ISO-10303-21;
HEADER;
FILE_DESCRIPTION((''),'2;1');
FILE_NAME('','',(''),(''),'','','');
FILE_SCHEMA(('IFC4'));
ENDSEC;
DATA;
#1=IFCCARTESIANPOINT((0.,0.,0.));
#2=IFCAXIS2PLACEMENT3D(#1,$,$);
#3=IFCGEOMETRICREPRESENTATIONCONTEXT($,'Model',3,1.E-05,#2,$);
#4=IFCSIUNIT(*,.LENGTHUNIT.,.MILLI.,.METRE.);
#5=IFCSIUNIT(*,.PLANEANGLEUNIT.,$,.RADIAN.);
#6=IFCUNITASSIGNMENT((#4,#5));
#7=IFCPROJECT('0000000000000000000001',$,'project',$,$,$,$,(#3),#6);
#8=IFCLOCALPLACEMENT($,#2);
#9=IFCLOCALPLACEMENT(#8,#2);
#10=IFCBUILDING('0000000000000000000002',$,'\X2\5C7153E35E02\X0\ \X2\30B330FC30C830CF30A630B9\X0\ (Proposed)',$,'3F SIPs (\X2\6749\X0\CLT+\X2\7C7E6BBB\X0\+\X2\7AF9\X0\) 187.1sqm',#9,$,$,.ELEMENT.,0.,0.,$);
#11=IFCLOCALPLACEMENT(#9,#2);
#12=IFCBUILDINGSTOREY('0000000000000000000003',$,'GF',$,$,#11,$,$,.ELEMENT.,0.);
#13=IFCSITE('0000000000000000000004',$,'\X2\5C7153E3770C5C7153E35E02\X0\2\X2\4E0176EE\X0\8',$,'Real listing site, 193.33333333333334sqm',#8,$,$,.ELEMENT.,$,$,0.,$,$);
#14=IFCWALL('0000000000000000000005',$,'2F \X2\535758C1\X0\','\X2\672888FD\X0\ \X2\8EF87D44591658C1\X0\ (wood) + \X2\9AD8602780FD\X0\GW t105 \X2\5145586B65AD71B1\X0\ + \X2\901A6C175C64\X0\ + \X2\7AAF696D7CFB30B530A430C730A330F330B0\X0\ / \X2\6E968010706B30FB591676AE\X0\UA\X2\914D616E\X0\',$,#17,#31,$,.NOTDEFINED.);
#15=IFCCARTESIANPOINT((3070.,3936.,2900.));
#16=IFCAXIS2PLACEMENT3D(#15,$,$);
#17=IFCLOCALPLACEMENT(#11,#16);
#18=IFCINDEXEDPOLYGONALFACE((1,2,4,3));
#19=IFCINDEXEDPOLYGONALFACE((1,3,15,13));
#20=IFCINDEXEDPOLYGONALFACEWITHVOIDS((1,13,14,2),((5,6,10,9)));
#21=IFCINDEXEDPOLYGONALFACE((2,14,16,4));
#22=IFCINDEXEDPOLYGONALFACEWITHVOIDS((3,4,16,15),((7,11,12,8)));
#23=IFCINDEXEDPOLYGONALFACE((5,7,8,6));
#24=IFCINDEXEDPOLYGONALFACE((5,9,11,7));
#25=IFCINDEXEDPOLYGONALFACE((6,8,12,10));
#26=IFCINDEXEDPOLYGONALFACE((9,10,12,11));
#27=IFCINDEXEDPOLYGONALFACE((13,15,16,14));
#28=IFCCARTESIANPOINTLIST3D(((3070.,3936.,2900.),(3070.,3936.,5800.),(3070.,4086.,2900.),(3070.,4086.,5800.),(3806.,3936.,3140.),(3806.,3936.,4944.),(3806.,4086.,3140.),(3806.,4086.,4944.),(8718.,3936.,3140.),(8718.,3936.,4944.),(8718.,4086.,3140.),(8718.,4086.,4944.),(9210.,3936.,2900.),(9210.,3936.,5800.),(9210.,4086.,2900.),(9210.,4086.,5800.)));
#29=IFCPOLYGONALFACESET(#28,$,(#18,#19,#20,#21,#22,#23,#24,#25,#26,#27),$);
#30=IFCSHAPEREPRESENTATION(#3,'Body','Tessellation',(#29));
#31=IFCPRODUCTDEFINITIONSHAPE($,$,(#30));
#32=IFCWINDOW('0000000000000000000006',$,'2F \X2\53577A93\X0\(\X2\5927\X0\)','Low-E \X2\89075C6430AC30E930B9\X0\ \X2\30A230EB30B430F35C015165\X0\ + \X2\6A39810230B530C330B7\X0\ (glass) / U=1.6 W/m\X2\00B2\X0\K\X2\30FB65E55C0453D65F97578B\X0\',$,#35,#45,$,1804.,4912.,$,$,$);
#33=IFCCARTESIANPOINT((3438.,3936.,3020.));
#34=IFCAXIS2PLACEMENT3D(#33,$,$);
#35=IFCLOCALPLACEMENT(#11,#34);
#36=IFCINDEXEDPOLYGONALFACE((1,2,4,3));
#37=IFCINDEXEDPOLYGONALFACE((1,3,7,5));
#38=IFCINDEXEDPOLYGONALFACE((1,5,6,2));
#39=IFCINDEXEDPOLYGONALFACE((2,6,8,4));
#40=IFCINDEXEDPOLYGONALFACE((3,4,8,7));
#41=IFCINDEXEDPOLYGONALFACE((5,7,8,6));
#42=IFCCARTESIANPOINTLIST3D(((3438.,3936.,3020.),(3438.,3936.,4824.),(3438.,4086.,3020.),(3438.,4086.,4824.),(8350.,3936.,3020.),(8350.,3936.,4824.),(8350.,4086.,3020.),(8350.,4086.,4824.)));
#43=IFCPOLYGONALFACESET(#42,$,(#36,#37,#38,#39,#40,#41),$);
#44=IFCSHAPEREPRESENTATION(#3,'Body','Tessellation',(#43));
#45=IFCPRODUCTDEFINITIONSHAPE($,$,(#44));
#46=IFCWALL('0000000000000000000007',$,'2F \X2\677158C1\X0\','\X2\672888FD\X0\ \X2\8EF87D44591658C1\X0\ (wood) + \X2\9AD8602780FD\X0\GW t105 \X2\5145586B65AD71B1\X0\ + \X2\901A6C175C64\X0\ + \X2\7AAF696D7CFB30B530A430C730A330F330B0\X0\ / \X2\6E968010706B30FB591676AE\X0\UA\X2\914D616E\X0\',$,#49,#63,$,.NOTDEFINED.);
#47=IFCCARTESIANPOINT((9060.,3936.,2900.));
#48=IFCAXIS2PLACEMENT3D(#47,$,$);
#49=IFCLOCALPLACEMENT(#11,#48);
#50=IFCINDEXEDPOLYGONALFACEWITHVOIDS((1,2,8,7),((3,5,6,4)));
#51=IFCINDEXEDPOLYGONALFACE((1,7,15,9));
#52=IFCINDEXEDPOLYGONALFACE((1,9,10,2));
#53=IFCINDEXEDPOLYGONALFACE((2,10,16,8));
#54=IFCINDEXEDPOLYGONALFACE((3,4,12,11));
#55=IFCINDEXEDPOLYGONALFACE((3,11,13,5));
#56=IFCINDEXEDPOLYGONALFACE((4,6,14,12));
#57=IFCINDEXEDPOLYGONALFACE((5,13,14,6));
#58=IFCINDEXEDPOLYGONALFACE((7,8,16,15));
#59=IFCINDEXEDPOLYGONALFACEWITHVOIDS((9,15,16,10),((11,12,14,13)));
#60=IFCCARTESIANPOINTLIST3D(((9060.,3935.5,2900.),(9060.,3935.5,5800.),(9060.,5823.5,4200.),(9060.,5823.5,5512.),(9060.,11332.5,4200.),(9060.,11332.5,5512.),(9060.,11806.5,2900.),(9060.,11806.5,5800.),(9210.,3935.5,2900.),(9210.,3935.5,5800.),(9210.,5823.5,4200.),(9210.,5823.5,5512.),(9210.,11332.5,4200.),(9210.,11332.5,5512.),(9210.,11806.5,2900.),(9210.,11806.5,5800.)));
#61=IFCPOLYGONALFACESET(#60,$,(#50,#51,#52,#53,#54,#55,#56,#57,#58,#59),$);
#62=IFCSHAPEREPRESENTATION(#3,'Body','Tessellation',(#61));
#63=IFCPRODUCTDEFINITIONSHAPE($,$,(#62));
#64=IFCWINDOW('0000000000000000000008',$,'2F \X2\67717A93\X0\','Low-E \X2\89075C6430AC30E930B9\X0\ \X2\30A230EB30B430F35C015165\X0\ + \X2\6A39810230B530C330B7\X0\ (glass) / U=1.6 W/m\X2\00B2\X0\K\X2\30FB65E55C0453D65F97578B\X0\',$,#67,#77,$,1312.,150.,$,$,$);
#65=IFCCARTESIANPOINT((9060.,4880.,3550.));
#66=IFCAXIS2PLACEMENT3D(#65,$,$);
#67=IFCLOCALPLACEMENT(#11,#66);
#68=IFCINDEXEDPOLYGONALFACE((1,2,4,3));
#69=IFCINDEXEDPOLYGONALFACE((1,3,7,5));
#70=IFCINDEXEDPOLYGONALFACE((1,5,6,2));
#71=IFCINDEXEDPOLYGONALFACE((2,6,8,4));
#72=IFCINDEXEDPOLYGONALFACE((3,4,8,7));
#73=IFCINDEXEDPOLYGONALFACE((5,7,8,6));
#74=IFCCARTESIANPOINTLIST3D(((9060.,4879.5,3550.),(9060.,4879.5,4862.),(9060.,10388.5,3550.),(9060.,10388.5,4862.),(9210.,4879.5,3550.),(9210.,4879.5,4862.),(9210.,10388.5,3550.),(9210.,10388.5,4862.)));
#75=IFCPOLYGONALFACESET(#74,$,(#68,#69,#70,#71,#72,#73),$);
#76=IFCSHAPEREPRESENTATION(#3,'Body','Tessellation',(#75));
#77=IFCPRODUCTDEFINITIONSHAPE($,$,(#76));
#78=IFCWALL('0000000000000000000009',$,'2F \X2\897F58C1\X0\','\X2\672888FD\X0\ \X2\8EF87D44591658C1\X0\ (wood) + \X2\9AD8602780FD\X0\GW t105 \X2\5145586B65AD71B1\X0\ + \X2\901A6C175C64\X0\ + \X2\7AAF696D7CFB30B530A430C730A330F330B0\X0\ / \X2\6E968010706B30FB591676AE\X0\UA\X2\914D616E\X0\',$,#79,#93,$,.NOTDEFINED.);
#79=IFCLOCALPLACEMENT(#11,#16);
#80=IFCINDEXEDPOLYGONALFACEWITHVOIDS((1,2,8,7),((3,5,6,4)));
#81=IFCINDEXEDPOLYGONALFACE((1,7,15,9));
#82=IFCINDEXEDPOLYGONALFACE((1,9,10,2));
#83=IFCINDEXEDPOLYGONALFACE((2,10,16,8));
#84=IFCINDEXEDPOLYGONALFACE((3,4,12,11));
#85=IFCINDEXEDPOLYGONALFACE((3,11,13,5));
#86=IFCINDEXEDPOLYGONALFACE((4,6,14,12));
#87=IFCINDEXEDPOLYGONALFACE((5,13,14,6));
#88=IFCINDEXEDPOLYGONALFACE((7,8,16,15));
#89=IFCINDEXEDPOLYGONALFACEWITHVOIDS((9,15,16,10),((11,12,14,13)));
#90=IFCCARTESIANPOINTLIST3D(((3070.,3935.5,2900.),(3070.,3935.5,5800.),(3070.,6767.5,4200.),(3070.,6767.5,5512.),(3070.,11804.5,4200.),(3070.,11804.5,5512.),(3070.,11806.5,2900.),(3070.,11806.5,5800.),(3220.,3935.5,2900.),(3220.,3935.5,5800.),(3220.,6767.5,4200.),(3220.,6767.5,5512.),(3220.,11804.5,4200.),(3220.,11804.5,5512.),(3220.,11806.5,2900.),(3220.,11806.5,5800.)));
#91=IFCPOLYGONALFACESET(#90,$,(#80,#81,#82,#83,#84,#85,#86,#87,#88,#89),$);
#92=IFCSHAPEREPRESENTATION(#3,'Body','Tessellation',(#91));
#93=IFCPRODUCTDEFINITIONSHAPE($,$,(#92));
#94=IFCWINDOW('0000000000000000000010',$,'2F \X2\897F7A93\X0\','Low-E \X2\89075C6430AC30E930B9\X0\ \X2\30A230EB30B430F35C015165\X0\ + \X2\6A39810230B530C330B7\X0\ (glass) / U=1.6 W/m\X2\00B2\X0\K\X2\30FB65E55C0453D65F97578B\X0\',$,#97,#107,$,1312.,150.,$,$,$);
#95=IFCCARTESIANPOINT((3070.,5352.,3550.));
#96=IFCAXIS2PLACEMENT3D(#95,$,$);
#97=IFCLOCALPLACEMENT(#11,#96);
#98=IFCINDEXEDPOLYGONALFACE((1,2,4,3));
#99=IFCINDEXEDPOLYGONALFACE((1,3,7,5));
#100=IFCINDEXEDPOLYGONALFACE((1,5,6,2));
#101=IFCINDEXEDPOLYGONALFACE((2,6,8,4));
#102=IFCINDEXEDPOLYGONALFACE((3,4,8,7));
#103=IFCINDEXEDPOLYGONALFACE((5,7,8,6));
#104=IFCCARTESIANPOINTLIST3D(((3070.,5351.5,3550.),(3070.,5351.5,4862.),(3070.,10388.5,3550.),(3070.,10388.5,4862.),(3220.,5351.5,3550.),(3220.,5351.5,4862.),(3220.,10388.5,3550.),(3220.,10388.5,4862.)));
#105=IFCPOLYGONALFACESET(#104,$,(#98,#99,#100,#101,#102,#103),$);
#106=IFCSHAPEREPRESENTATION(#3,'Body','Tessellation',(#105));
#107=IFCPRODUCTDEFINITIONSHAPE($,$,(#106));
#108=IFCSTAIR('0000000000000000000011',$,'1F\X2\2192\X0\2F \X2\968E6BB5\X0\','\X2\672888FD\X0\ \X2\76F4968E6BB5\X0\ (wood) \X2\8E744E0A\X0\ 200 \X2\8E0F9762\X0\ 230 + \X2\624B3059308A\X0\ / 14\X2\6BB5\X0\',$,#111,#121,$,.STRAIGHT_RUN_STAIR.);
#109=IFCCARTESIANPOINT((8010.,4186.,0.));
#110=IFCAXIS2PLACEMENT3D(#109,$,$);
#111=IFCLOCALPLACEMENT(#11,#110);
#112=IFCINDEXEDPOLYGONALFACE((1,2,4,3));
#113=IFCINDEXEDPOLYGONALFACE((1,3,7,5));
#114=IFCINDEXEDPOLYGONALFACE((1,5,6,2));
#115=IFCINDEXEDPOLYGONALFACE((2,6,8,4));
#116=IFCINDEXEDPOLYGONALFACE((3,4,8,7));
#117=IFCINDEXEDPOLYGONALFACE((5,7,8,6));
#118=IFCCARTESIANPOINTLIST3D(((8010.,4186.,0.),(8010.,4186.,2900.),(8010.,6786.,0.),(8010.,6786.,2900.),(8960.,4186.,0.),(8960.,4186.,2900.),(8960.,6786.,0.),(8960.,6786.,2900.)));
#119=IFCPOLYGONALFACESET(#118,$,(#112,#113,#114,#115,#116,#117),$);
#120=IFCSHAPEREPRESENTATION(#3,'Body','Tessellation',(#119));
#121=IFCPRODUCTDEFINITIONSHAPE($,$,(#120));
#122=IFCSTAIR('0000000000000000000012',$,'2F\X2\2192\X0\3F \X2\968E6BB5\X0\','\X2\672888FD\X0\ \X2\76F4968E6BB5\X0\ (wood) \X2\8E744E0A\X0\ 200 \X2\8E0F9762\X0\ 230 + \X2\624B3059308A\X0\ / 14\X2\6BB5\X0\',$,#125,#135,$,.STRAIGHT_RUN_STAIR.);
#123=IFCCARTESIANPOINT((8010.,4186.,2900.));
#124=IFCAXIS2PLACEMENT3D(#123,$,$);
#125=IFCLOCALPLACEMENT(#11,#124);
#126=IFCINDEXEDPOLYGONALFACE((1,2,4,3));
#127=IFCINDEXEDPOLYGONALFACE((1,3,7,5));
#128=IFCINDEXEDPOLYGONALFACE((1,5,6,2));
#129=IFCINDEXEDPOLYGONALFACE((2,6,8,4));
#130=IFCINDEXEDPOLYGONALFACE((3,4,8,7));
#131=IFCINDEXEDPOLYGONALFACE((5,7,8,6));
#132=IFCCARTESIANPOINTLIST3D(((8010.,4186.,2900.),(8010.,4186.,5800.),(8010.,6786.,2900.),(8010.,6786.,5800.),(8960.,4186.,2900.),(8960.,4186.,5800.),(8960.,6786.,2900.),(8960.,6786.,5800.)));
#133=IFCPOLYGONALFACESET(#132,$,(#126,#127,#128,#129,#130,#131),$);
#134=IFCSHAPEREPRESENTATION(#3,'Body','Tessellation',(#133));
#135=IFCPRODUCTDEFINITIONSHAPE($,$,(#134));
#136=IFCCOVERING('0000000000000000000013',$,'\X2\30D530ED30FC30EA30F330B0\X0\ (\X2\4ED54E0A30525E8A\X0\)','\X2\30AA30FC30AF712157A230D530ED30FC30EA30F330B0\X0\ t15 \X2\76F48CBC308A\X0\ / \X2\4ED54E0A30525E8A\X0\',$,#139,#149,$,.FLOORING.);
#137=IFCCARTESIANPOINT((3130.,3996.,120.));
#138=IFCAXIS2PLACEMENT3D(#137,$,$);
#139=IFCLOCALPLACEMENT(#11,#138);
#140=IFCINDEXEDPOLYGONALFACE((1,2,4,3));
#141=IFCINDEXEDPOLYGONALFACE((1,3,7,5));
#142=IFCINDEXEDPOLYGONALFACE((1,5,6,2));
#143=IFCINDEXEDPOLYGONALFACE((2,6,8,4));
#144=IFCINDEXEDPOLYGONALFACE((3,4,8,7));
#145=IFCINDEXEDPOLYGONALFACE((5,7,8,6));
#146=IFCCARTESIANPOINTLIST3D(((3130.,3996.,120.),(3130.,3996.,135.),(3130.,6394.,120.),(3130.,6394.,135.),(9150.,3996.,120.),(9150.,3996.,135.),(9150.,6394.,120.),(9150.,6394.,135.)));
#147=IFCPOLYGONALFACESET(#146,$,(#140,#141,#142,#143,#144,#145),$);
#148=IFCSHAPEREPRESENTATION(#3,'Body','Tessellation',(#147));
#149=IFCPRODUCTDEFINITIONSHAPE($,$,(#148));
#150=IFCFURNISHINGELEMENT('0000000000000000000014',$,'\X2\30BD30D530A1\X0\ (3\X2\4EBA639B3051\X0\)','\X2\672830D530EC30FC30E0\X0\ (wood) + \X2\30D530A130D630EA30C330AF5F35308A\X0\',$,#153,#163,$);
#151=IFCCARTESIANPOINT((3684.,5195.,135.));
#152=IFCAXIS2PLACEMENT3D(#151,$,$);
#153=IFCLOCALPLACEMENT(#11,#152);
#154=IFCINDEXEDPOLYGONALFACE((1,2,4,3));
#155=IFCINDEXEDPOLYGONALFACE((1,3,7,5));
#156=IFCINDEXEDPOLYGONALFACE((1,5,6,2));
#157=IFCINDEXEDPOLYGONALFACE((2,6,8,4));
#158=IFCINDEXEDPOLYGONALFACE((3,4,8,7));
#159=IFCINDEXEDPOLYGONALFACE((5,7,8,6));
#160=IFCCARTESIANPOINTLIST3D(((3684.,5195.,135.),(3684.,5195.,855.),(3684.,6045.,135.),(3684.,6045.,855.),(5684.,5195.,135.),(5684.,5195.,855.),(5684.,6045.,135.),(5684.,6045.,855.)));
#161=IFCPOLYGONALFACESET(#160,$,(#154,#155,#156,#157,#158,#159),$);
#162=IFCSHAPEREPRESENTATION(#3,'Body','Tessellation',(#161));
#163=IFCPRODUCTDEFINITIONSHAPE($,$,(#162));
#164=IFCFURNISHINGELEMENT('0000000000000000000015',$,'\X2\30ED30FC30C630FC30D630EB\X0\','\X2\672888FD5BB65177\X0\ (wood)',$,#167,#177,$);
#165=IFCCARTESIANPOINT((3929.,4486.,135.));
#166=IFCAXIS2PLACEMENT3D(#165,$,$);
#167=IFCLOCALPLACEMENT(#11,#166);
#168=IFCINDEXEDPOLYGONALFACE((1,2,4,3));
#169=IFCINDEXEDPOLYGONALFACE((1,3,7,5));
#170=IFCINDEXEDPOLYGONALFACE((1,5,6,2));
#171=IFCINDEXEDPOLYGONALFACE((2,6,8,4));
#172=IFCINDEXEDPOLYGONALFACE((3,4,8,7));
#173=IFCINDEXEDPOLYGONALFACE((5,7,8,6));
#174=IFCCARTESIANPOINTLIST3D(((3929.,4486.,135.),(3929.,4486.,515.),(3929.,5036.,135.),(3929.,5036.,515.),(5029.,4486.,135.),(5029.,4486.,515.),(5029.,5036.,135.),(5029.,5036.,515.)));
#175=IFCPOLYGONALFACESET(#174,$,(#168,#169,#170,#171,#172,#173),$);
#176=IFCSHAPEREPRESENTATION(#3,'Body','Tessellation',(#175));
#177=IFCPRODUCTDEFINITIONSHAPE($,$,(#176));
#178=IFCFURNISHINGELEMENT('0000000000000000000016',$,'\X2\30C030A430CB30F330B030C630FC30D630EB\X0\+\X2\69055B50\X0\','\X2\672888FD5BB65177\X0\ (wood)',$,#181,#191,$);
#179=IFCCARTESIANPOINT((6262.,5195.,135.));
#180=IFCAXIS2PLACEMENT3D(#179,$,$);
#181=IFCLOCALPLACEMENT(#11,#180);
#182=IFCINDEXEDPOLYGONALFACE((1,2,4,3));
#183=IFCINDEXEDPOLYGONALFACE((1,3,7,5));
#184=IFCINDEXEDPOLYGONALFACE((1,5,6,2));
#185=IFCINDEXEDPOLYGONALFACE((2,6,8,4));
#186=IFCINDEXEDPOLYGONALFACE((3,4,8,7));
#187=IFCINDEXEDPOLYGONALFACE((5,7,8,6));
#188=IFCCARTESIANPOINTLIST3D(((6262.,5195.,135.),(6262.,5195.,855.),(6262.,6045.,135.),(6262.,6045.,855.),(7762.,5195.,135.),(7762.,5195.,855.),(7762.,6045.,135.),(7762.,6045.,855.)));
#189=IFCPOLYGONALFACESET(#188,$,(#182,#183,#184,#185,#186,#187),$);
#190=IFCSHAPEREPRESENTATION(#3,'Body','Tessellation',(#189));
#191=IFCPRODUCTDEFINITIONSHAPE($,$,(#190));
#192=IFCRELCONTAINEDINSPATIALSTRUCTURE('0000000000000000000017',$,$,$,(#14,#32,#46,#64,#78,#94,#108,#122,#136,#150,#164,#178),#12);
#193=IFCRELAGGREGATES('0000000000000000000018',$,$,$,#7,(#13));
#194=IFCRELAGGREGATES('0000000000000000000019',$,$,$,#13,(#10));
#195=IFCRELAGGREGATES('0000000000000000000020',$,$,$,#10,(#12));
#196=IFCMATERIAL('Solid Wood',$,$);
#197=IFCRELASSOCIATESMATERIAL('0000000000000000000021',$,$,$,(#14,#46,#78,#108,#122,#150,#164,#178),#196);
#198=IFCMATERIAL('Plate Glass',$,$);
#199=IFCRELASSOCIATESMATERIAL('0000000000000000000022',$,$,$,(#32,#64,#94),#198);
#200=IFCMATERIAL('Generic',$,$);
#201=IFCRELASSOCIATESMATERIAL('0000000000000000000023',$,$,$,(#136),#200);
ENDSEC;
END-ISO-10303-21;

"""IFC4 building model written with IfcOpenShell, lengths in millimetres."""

from ifc_helpers import new_model, si_unit, frame, frame_2d, origin, place, context, project, spatial, rectangle, extrude, material, element, fill, save


model = new_model("IFC4")

# Units and contexts
model_context = context("Model", 3, precision=1e-05, world=origin())
ifc_project = project(units=[si_unit("LENGTHUNIT", "METRE", prefix="MILLI"), si_unit("PLANEANGLEUNIT", "RADIAN")], contexts=[model_context])

# Site, building, storey
site_placement = place(None, origin())
site = spatial("IfcSite", under=ifc_project, at=site_placement, Name="山口県山口市2丁目8", ObjectType="Real listing site, 193.33333333333334sqm", CompositionType="ELEMENT", RefElevation=0.0)
building_placement = place(site_placement, origin())
building = spatial("IfcBuilding", under=site, at=building_placement, Name="山口市 コートハウス (Proposed)", ObjectType="3F SIPs (杉CLT+籾殻+竹) 187.1sqm", CompositionType="ELEMENT", ElevationOfRefHeight=0.0, ElevationOfTerrain=0.0)
storey_placement = place(building_placement, origin())
storey = spatial("IfcBuildingStorey", under=building, at=storey_placement, Name="GF", CompositionType="ELEMENT", Elevation=0.0)

# Shared definitions
ifc_material_1 = material(Name="Solid Wood")
ifc_material_2 = material(Name="Generic")

# Shared definitions
ifc_material_3 = material(Name="Plate Glass")

# Walls, openings, windows
wall_1_placement = place(storey_placement, frame((3070.0, 3936.0, 2900.0)))
wall_1 = element("IfcWall", 1, at=wall_1_placement, inside=storey, material=ifc_material_1, Name="2F 南壁", Description="木製 軸組外壁 (wood) + 高性能GW t105 充填断熱 + 通気層 + 窯業系サイディング / 準耐火・外皮UA配慮", PredefinedType="NOTDEFINED", context=model_context, shape_type="SweptSolid", body=[
    extrude(rectangle(XDim=6140.0, YDim=150.0, at=frame_2d((3070.0, 75.0))), frame((3070.0, 3936.0, 2900.0)), (0.0, 0.0, 1.0), 2900.0),
])
opening_1_placement = place(storey_placement, frame((3438.0, 3936.0, 3020.0)))
opening_1 = element("IfcOpeningElement", 2, at=opening_1_placement, cuts=wall_1, PredefinedType="NOTDEFINED", context=model_context, shape_type="SweptSolid", body=[
    extrude(rectangle(XDim=4912.0, YDim=150.0, at=frame_2d((2456.0, 75.0))), frame((3438.0, 3936.0, 3020.0)), (0.0, 0.0, 1.0), 1804.0),
])
window_1_placement = place(storey_placement, frame((3438.0, 3936.0, 3020.0)))
window_1 = element("IfcWindow", 3, at=window_1_placement, inside=storey, material=ifc_material_3, Name="2F 南窓(大)", Description="Low-E 複層ガラス アルゴン封入 + 樹脂サッシ (glass) / U=1.6 W/m²K・日射取得型", OverallHeight=1804.0, OverallWidth=4912.0, context=model_context, shape_type="SweptSolid", body=[
    extrude(rectangle(XDim=4912.0, YDim=150.0, at=frame_2d((2456.0, 75.0))), frame((3438.0, 3936.0, 3020.0)), (0.0, 0.0, 1.0), 1804.0),
])
fill(opening_1, window_1)
wall_2_placement = place(storey_placement, frame((9060.0, 3936.0, 2900.0)))
wall_2 = element("IfcWall", 4, at=wall_2_placement, inside=storey, material=ifc_material_1, Name="2F 東壁", Description="木製 軸組外壁 (wood) + 高性能GW t105 充填断熱 + 通気層 + 窯業系サイディング / 準耐火・外皮UA配慮", PredefinedType="NOTDEFINED", context=model_context, shape_type="SweptSolid", body=[
    extrude(rectangle(XDim=150.0, YDim=7871.0, at=frame_2d((75.0, 3935.0))), frame((9060.0, 3936.0, 2900.0)), (0.0, 0.0, 1.0), 2900.0),
])
opening_2_placement = place(storey_placement, frame((9060.0, 4880.0, 3550.0)))
opening_2 = element("IfcOpeningElement", 5, at=opening_2_placement, cuts=wall_2, PredefinedType="NOTDEFINED", context=model_context, shape_type="SweptSolid", body=[
    extrude(rectangle(XDim=150.0, YDim=5509.0, at=frame_2d((75.0, 2754.0))), frame((9060.0, 4880.0, 3550.0)), (0.0, 0.0, 1.0), 1312.0),
])
window_2_placement = place(storey_placement, frame((9060.0, 4880.0, 3550.0)))
window_2 = element("IfcWindow", 6, at=window_2_placement, inside=storey, material=ifc_material_3, Name="2F 東窓", Description="Low-E 複層ガラス アルゴン封入 + 樹脂サッシ (glass) / U=1.6 W/m²K・日射取得型", OverallHeight=1312.0, OverallWidth=150.0, context=model_context, shape_type="SweptSolid", body=[
    extrude(rectangle(XDim=150.0, YDim=5509.0, at=frame_2d((75.0, 2754.0))), frame((9060.0, 4880.0, 3550.0)), (0.0, 0.0, 1.0), 1312.0),
])
fill(opening_2, window_2)
wall_3_placement = place(storey_placement, frame((3070.0, 3936.0, 2900.0)))
wall_3 = element("IfcWall", 7, at=wall_3_placement, inside=storey, material=ifc_material_1, Name="2F 西壁", Description="木製 軸組外壁 (wood) + 高性能GW t105 充填断熱 + 通気層 + 窯業系サイディング / 準耐火・外皮UA配慮", PredefinedType="NOTDEFINED", context=model_context, shape_type="SweptSolid", body=[
    extrude(rectangle(XDim=150.0, YDim=7871.0, at=frame_2d((75.0, 3935.0))), frame((3070.0, 3936.0, 2900.0)), (0.0, 0.0, 1.0), 2900.0),
])
opening_3_placement = place(storey_placement, frame((3070.0, 5352.0, 3550.0)))
opening_3 = element("IfcOpeningElement", 8, at=opening_3_placement, cuts=wall_3, PredefinedType="NOTDEFINED", context=model_context, shape_type="SweptSolid", body=[
    extrude(rectangle(XDim=150.0, YDim=5037.0, at=frame_2d((75.0, 2518.0))), frame((3070.0, 5352.0, 3550.0)), (0.0, 0.0, 1.0), 1312.0),
])
window_3_placement = place(storey_placement, frame((3070.0, 5352.0, 3550.0)))
window_3 = element("IfcWindow", 9, at=window_3_placement, inside=storey, material=ifc_material_3, Name="2F 西窓", Description="Low-E 複層ガラス アルゴン封入 + 樹脂サッシ (glass) / U=1.6 W/m²K・日射取得型", OverallHeight=1312.0, OverallWidth=150.0, context=model_context, shape_type="SweptSolid", body=[
    extrude(rectangle(XDim=150.0, YDim=5037.0, at=frame_2d((75.0, 2518.0))), frame((3070.0, 5352.0, 3550.0)), (0.0, 0.0, 1.0), 1312.0),
])
fill(opening_3, window_3)

# Stairs
stair_1_placement = place(storey_placement, frame((8010.0, 4186.0, 0.0)))
element("IfcStair", 10, at=stair_1_placement, inside=storey, material=ifc_material_1, Name="1F→2F 階段", Description="木製 直階段 (wood) 蹴上 200 踏面 230 + 手すり / 14段", PredefinedType="STRAIGHT_RUN_STAIR", context=model_context, shape_type="SweptSolid", body=[
    extrude(rectangle(XDim=950.0, YDim=2600.0, at=frame_2d((475.0, 1300.0))), frame((8010.0, 4186.0, 0.0)), (0.0, 0.0, 1.0), 2900.0),
])
stair_2_placement = place(storey_placement, frame((8010.0, 4186.0, 2900.0)))
element("IfcStair", 11, at=stair_2_placement, inside=storey, material=ifc_material_1, Name="2F→3F 階段", Description="木製 直階段 (wood) 蹴上 200 踏面 230 + 手すり / 14段", PredefinedType="STRAIGHT_RUN_STAIR", context=model_context, shape_type="SweptSolid", body=[
    extrude(rectangle(XDim=950.0, YDim=2600.0, at=frame_2d((475.0, 1300.0))), frame((8010.0, 4186.0, 2900.0)), (0.0, 0.0, 1.0), 2900.0),
])

# Covering
covering_placement = place(storey_placement, frame((3130.0, 3996.0, 120.0)))
element("IfcCovering", 12, at=covering_placement, inside=storey, material=ifc_material_2, Name="フローリング (仕上げ床)", Description="オーク無垢フローリング t15 直貼り / 仕上げ床", PredefinedType="FLOORING", context=model_context, shape_type="SweptSolid", body=[
    extrude(rectangle(XDim=6020.0, YDim=2398.0, at=frame_2d((3010.0, 1199.0))), frame((3130.0, 3996.0, 120.0)), (0.0, 0.0, 1.0), 15.0),
])

# Furnishing elements
furnishing_1_placement = place(storey_placement, frame((3684.0, 5195.0, 135.0)))
element("IfcFurnishingElement", 13, at=furnishing_1_placement, inside=storey, material=ifc_material_1, Name="ソファ (3人掛け)", Description="木フレーム (wood) + ファブリック張り", context=model_context, shape_type="SweptSolid", body=[
    extrude(rectangle(XDim=2000.0, YDim=850.0, at=frame_2d((1000.0, 425.0))), frame((3684.0, 5195.0, 135.0)), (0.0, 0.0, 1.0), 720.0),
])
furnishing_2_placement = place(storey_placement, frame((3929.0, 4486.0, 135.0)))
element("IfcFurnishingElement", 14, at=furnishing_2_placement, inside=storey, material=ifc_material_1, Name="ローテーブル", Description="木製家具 (wood)", context=model_context, shape_type="SweptSolid", body=[
    extrude(rectangle(XDim=1100.0, YDim=550.0, at=frame_2d((550.0, 275.0))), frame((3929.0, 4486.0, 135.0)), (0.0, 0.0, 1.0), 380.0),
])
furnishing_3_placement = place(storey_placement, frame((6262.0, 5195.0, 135.0)))
element("IfcFurnishingElement", 15, at=furnishing_3_placement, inside=storey, material=ifc_material_1, Name="ダイニングテーブル+椅子", Description="木製家具 (wood)", context=model_context, shape_type="SweptSolid", body=[
    extrude(rectangle(XDim=1500.0, YDim=850.0, at=frame_2d((750.0, 425.0))), frame((6262.0, 5195.0, 135.0)), (0.0, 0.0, 1.0), 720.0),
])

save(model, "model.ifc")
